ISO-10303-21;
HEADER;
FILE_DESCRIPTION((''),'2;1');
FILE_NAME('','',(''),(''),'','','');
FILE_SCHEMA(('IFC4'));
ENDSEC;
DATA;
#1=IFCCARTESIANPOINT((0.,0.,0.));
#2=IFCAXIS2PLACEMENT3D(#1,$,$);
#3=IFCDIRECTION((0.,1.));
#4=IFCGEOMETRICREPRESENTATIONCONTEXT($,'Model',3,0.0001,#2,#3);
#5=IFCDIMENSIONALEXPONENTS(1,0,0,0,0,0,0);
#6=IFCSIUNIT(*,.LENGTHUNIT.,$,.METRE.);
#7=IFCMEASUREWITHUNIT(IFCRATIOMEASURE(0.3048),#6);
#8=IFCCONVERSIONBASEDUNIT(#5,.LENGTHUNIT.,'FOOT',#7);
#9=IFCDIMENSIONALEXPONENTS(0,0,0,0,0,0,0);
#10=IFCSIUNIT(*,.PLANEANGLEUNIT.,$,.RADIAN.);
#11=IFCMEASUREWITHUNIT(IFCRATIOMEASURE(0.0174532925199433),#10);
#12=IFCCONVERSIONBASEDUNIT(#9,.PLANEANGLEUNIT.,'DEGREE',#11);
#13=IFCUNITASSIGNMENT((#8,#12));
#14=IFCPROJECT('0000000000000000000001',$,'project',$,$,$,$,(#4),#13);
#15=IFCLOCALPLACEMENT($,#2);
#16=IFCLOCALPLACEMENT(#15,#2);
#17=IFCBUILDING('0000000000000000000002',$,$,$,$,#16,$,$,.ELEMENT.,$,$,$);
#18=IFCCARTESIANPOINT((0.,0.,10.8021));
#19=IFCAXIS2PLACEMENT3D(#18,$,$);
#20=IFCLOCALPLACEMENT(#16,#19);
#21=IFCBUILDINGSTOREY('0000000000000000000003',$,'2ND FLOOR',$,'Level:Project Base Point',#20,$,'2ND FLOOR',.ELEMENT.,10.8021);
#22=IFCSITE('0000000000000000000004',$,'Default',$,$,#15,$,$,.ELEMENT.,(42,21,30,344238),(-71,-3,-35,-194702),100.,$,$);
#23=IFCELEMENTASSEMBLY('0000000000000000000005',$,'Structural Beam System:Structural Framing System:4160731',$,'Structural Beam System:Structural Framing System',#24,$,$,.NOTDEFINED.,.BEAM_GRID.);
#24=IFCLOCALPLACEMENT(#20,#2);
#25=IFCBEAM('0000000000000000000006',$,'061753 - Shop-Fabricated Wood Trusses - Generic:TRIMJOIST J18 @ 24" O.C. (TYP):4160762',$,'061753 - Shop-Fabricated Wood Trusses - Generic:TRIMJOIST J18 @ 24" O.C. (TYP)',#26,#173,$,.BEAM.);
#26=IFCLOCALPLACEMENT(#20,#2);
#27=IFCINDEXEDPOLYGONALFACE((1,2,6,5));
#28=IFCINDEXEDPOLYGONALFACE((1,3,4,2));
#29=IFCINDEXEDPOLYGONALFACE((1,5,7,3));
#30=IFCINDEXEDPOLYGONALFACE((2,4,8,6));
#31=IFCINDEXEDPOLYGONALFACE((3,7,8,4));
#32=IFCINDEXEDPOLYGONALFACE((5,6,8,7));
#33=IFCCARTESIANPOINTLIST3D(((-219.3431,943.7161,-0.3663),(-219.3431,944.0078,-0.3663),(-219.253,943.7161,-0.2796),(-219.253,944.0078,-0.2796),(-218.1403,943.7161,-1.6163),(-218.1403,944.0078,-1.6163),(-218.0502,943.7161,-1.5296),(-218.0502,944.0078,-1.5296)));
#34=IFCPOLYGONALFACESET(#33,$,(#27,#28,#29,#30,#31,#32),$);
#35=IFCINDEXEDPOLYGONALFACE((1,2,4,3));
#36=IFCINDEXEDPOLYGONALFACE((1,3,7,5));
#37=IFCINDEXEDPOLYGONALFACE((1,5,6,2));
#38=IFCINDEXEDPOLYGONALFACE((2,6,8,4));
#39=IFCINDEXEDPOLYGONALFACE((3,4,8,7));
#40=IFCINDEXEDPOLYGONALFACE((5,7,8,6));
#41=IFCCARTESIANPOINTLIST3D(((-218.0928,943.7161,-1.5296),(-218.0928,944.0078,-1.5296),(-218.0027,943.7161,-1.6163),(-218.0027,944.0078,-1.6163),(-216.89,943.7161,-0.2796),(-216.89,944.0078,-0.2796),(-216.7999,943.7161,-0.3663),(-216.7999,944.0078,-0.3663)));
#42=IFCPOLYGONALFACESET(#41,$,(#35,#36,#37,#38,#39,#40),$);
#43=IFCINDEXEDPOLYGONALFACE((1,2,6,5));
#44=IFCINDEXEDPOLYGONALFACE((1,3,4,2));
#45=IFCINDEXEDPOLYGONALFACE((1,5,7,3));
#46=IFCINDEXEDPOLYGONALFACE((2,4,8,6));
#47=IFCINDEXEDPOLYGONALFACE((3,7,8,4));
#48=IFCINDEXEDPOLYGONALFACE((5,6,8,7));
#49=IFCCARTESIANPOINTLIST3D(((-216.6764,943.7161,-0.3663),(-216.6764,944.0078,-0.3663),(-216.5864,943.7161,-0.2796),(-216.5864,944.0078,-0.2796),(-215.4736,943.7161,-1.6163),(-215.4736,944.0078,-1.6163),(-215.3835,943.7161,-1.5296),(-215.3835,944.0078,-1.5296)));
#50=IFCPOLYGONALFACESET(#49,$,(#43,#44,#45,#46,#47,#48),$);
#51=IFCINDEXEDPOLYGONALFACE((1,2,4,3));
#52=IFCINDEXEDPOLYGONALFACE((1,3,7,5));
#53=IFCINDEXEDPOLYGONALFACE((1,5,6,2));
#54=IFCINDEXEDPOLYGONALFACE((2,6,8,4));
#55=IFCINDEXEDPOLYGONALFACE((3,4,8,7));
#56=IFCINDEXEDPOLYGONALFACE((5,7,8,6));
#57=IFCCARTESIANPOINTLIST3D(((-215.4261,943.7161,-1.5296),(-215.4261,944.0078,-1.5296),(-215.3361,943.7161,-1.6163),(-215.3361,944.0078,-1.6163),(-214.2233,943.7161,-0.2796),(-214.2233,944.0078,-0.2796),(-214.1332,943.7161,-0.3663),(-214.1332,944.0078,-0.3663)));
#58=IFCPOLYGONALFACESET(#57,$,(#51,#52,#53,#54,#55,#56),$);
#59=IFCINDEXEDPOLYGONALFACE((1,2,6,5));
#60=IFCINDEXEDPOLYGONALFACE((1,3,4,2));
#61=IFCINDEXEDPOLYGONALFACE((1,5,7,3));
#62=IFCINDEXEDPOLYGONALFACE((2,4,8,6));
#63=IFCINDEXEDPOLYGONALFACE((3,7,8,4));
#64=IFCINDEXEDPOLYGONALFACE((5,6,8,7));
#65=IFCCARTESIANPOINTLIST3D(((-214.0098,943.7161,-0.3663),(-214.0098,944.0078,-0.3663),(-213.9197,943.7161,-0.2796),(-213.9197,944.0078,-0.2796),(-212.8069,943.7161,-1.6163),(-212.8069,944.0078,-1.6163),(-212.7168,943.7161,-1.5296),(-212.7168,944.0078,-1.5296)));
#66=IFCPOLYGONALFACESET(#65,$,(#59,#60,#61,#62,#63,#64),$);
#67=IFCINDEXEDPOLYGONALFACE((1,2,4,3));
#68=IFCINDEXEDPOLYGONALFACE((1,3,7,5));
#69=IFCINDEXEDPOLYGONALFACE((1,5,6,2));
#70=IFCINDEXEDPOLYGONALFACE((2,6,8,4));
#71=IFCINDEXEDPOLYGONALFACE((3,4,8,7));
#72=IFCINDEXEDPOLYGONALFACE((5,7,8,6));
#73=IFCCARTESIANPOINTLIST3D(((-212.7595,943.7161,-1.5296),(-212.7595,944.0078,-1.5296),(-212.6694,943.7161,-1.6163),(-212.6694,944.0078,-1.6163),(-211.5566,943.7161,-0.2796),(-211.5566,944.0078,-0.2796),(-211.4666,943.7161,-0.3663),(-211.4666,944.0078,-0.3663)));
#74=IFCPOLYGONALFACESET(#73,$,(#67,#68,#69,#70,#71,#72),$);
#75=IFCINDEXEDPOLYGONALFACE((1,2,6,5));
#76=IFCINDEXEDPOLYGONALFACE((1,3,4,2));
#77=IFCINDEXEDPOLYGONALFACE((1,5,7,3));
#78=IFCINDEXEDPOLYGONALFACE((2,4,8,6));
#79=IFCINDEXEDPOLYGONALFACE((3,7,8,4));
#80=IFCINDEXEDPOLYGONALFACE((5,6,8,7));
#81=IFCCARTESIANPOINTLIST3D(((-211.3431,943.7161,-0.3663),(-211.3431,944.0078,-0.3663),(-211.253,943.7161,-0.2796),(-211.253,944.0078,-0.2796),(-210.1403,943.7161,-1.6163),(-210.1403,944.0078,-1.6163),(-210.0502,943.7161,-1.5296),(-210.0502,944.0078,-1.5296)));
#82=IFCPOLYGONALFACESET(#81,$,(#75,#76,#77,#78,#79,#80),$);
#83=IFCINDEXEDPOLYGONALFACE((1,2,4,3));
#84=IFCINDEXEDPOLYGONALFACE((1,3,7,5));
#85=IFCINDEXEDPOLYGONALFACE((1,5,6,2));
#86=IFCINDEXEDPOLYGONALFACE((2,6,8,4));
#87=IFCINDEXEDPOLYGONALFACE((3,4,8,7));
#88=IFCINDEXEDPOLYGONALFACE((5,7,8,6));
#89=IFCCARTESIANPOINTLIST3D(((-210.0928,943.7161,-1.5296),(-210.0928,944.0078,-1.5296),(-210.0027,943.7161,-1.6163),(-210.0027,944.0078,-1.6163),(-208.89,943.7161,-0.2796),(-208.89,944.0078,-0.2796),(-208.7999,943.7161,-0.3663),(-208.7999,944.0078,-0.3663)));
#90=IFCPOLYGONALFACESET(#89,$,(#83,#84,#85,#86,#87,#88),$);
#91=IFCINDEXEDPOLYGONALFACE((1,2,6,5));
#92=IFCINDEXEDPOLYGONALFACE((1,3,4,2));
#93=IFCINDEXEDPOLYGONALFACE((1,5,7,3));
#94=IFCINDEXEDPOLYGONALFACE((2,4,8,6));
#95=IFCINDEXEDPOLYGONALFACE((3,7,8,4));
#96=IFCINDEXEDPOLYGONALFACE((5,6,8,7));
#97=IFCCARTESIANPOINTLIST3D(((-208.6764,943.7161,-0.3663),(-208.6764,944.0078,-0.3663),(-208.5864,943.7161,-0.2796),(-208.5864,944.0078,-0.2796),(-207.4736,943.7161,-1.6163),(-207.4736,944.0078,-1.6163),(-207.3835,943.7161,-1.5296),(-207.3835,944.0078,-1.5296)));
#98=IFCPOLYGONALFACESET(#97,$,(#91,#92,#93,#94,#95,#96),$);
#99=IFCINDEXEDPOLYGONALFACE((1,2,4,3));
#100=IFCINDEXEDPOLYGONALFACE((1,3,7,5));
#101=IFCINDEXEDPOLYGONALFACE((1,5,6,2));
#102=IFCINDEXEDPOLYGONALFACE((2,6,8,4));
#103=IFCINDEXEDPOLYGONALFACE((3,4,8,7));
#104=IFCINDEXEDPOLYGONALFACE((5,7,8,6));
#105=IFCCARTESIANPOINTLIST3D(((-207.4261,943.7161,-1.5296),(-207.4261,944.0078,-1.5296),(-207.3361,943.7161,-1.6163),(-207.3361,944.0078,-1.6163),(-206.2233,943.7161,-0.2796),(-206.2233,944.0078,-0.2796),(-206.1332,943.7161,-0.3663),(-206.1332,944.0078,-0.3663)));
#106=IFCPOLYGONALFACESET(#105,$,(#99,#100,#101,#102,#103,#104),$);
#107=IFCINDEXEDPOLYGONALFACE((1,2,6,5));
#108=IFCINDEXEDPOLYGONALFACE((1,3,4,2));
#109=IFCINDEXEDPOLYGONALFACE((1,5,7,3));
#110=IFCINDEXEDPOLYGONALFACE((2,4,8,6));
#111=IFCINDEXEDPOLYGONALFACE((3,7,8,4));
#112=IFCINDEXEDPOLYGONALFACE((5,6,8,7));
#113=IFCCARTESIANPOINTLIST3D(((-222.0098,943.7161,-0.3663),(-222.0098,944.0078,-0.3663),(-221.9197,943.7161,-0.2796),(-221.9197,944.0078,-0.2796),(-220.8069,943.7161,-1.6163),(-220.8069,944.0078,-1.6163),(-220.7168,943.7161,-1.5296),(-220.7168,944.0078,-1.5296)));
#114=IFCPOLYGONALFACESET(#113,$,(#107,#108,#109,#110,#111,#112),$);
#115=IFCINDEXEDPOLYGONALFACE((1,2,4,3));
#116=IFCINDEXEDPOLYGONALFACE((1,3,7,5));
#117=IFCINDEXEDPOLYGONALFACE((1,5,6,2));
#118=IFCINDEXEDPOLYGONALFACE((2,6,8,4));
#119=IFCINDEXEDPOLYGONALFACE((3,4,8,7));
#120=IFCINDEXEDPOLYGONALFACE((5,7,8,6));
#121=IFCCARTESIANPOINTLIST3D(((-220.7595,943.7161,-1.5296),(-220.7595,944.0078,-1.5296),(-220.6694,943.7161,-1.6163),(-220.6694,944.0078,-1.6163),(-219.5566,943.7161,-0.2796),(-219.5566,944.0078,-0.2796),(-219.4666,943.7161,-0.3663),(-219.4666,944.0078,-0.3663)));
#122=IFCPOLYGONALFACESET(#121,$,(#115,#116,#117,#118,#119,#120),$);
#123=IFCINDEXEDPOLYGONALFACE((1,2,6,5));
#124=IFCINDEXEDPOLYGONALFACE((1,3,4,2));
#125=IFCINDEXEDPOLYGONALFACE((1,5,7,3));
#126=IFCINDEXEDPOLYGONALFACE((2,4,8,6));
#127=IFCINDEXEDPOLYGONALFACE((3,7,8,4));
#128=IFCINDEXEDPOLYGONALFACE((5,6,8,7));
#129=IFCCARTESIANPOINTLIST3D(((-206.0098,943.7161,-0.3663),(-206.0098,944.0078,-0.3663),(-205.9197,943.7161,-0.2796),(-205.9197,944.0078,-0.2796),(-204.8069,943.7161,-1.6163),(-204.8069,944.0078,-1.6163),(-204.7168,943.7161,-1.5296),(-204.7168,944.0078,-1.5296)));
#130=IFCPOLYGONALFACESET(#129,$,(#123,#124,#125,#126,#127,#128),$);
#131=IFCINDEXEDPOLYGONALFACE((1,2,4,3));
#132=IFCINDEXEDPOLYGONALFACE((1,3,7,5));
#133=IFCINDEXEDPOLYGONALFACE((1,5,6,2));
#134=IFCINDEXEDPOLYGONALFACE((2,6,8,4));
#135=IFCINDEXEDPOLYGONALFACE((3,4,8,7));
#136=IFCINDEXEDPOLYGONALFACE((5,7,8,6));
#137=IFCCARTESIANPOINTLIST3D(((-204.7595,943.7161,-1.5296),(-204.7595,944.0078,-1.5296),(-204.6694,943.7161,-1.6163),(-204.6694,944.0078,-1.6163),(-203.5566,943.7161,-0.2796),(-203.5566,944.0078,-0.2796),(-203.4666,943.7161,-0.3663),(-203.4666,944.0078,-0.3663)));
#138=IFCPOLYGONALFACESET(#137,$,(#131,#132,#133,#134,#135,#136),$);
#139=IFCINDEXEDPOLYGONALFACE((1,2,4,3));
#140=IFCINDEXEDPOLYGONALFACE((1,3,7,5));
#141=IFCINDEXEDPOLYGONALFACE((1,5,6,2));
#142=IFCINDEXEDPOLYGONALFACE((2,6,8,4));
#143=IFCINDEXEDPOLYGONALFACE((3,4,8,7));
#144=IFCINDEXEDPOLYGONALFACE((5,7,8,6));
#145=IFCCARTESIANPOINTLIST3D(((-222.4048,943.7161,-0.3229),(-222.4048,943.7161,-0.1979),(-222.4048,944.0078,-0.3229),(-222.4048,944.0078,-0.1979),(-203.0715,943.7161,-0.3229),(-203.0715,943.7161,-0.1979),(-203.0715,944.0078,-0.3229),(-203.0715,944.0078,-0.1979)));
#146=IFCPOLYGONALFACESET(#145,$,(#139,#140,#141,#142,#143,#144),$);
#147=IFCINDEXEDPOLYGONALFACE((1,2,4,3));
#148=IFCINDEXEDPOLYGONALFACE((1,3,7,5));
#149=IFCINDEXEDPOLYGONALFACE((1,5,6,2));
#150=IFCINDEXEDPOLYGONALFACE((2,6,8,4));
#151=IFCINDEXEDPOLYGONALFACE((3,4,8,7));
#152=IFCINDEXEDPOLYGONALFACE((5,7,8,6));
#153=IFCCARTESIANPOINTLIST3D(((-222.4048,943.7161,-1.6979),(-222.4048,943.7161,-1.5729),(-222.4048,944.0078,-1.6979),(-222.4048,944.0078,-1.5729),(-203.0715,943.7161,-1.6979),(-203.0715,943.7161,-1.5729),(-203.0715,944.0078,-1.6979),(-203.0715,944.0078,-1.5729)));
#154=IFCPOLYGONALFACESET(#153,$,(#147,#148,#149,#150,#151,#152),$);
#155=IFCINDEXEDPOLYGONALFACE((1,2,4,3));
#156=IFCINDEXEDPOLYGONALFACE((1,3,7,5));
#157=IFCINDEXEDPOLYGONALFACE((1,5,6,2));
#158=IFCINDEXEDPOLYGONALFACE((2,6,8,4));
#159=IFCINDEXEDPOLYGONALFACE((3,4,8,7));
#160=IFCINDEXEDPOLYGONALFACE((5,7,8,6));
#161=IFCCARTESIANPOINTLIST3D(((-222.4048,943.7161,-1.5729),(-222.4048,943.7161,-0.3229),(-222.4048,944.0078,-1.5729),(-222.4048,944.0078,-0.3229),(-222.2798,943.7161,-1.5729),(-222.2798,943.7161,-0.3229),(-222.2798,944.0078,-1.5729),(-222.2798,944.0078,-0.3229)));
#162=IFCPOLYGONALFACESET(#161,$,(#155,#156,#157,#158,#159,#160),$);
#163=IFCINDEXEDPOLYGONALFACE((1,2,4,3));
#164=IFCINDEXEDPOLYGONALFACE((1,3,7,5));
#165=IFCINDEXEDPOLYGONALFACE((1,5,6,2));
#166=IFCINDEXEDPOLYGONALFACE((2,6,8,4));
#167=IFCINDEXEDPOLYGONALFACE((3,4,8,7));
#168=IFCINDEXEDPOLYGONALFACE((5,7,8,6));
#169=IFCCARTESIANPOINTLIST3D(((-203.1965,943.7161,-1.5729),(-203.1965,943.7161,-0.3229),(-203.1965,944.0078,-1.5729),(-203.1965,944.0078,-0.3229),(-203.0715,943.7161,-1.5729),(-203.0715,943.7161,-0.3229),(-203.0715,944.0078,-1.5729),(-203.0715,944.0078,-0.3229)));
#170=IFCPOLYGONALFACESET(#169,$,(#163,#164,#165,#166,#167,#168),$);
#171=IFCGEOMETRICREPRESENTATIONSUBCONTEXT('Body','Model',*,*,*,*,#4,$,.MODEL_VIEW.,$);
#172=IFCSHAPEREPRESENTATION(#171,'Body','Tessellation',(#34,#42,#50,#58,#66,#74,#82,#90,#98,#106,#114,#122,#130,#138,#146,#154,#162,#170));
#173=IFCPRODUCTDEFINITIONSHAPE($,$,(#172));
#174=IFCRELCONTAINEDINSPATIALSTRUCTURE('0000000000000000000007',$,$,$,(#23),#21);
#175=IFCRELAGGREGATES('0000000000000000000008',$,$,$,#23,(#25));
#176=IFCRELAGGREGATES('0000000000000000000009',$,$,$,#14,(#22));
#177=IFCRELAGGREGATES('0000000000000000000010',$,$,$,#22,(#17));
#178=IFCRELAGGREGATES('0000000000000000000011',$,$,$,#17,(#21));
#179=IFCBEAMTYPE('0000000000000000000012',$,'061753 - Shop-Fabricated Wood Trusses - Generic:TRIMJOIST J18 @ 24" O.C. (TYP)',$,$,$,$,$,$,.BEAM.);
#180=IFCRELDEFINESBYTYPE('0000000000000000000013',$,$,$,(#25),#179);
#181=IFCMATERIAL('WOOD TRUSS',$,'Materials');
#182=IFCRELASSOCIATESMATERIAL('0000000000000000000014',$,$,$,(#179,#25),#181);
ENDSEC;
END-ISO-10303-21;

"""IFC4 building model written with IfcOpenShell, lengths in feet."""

from ifc_helpers import new_model, entity, si_unit, converted_unit, direction, frame, frame_2d, origin, origin_2d_with_axis, place, context, subcontext, project, spatial, rectangle, extrude, source, transform, mapped, material, material_profile, profile_set, profile_usage, type_object, type_shapes, element, aggregate, save


model = new_model("IFC4")

# Units and contexts
model_context = context("Model", 3, precision=0.0001, world=origin(), true_north=direction((0.0, 1.0)))
body_context = subcontext(model_context, "Body", "Model", "MODEL_VIEW")
ifc_project = project(units=[converted_unit("LENGTHUNIT", "FOOT", entity("IfcRatioMeasure", 0.3048), si_unit("LENGTHUNIT", "METRE"), dimensions=[1, 0, 0, 0, 0, 0, 0]), converted_unit("PLANEANGLEUNIT", "DEGREE", entity("IfcRatioMeasure", 0.0174532925199433), si_unit("PLANEANGLEUNIT", "RADIAN"), dimensions=[0, 0, 0, 0, 0, 0, 0])], contexts=[model_context])

# Site, building, storey
site_placement = place(None, origin())
site = spatial("IfcSite", under=ifc_project, at=site_placement, Name="Default", CompositionType="ELEMENT", RefLatitude=(42, 21, 30, 344238), RefLongitude=(-71, -3, -35, -194702), RefElevation=100.0)
building_placement = place(site_placement, origin())
building = spatial("IfcBuilding", under=site, at=building_placement, CompositionType="ELEMENT")
storey_placement = place(building_placement, frame((0.0, 0.0, 10.8021)))
storey = spatial("IfcBuildingStorey", under=building, at=storey_placement, Name="2ND FLOOR", ObjectType="Level:Project Base Point", LongName="2ND FLOOR", CompositionType="ELEMENT", Elevation=10.8021)

# Element assembly, beam
ifc_material_1 = material(Name="WOOD TRUSS", Category="Materials")
ifc_material_profile_1 = material_profile(ifc_material_1, rectangle(XDim=1.7347, YDim=0.125, at=frame_2d((0.0, 0.0), x_axis=(1.0, 0.0))), Name="TRIMJOIST J18 @ 24\" O.C. (TYP)")
ifc_material_profile_2 = material_profile(ifc_material_1, rectangle(XDim=1.7347, YDim=0.125, at=frame_2d((0.0, 0.0), x_axis=(1.0, 0.0))), Name="TRIMJOIST J18 @ 24\" O.C. (TYP)")
ifc_material_profile_3 = material_profile(ifc_material_1, rectangle(XDim=1.7347, YDim=0.125, at=frame_2d((0.0, 0.0), x_axis=(1.0, 0.0))), Name="TRIMJOIST J18 @ 24\" O.C. (TYP)")
ifc_material_profile_4 = material_profile(ifc_material_1, rectangle(XDim=1.7347, YDim=0.125, at=frame_2d((0.0, 0.0), x_axis=(1.0, 0.0))), Name="TRIMJOIST J18 @ 24\" O.C. (TYP)")
ifc_material_profile_5 = material_profile(ifc_material_1, rectangle(XDim=1.7347, YDim=0.125, at=frame_2d((0.0, 0.0), x_axis=(1.0, 0.0))), Name="TRIMJOIST J18 @ 24\" O.C. (TYP)")
ifc_material_profile_6 = material_profile(ifc_material_1, rectangle(XDim=1.7347, YDim=0.125, at=frame_2d((0.0, 0.0), x_axis=(1.0, 0.0))), Name="TRIMJOIST J18 @ 24\" O.C. (TYP)")
ifc_material_profile_7 = material_profile(ifc_material_1, rectangle(XDim=1.7347, YDim=0.125, at=frame_2d((0.0, 0.0), x_axis=(1.0, 0.0))), Name="TRIMJOIST J18 @ 24\" O.C. (TYP)")
ifc_material_profile_8 = material_profile(ifc_material_1, rectangle(XDim=1.7347, YDim=0.125, at=frame_2d((0.0, 0.0), x_axis=(1.0, 0.0))), Name="TRIMJOIST J18 @ 24\" O.C. (TYP)")
ifc_material_profile_9 = material_profile(ifc_material_1, rectangle(XDim=1.7347, YDim=0.125, at=frame_2d((0.0, 0.0), x_axis=(1.0, 0.0))), Name="TRIMJOIST J18 @ 24\" O.C. (TYP)")
ifc_material_profile_10 = material_profile(ifc_material_1, rectangle(XDim=1.7347, YDim=0.125, at=origin_2d_with_axis()), Name="TRIMJOIST J18 @ 24\" O.C. (TYP)")
ifc_material_profile_11 = material_profile(ifc_material_1, rectangle(XDim=0.125, YDim=0.2917, at=origin_2d_with_axis()), Name="TRIMJOIST J18 @ 24\" O.C. (TYP)")
ifc_material_profile_12 = material_profile(ifc_material_1, rectangle(XDim=0.125, YDim=0.2917, at=origin_2d_with_axis()), Name="TRIMJOIST J18 @ 24\" O.C. (TYP)")
ifc_material_profile_13 = material_profile(ifc_material_1, rectangle(XDim=1.25, YDim=0.2917, at=origin_2d_with_axis()), Name="TRIMJOIST J18 @ 24\" O.C. (TYP)")
ifc_material_profile_14 = material_profile(ifc_material_1, rectangle(XDim=1.25, YDim=0.2917, at=origin_2d_with_axis()), Name="TRIMJOIST J18 @ 24\" O.C. (TYP)")
ifc_profile_set_1 = profile_set([ifc_material_profile_1, ifc_material_profile_2, ifc_material_profile_3, ifc_material_profile_4, ifc_material_profile_5, ifc_material_profile_6, ifc_material_profile_7, ifc_material_profile_8, ifc_material_profile_9, ifc_material_profile_10, ifc_material_profile_11, ifc_material_profile_12, ifc_material_profile_13, ifc_material_profile_14], Name="TRIMJOIST J18 @ 24\" O.C. (TYP)")
beam_type_1 = type_object("IfcBeamType", Name="061753 - Shop-Fabricated Wood Trusses - Generic:TRIMJOIST J18 @ 24\" O.C. (TYP)", PredefinedType="BEAM", material=ifc_profile_set_1)
shared_shape_1 = source(origin(), body_context, "Body", "SweptSolid", [
    extrude(rectangle(XDim=1.7347, YDim=0.125, at=frame_2d((0.0, 0.0), x_axis=(1.0, 0.0))), frame((5.9585, -0.1458, 0.0), z_axis=(0.0, 1.0, 0.0), x_axis=(0.693383, 0.0, 0.720569)), (0.0, 0.0, 1.0), 0.2917),
    extrude(rectangle(XDim=1.7347, YDim=0.125, at=origin_2d_with_axis()), frame((4.7082, -0.1458, 0.0), z_axis=(0.0, 1.0, 0.0), x_axis=(0.693383, 0.0, -0.720569)), (0.0, 0.0, 1.0), 0.2917),
    extrude(rectangle(XDim=1.7347, YDim=0.125, at=frame_2d((0.0, 0.0), x_axis=(1.0, 0.0))), frame((3.2918, -0.1458, 0.0), z_axis=(0.0, 1.0, 0.0), x_axis=(0.693383, 0.0, 0.720569)), (0.0, 0.0, 1.0), 0.2917),
    extrude(rectangle(XDim=1.7347, YDim=0.125, at=frame_2d((0.0, 0.0), x_axis=(1.0, 0.0))), frame((2.0415, -0.1458, 0.0), z_axis=(0.0, 1.0, 0.0), x_axis=(0.693383, 0.0, -0.720569)), (0.0, 0.0, 1.0), 0.2917),
    extrude(rectangle(XDim=1.7347, YDim=0.125, at=frame_2d((0.0, 0.0), x_axis=(1.0, 0.0))), frame((0.6251, -0.1458, 0.0), z_axis=(0.0, 1.0, 0.0), x_axis=(0.693383, 0.0, 0.720569)), (0.0, 0.0, 1.0), 0.2917),
    extrude(rectangle(XDim=1.7347, YDim=0.125, at=frame_2d((0.0, 0.0), x_axis=(1.0, 0.0))), frame((-0.6251, -0.1458, 0.0), z_axis=(0.0, 1.0, 0.0), x_axis=(0.693383, 0.0, -0.720569)), (0.0, 0.0, 1.0), 0.2917),
    extrude(rectangle(XDim=1.7347, YDim=0.125, at=frame_2d((0.0, 0.0), x_axis=(1.0, 0.0))), frame((-2.0415, -0.1458, 0.0), z_axis=(0.0, 1.0, 0.0), x_axis=(0.693383, 0.0, 0.720569)), (0.0, 0.0, 1.0), 0.2917),
    extrude(rectangle(XDim=1.7347, YDim=0.125, at=origin_2d_with_axis()), frame((-3.2918, -0.1458, 0.0), z_axis=(0.0, 1.0, 0.0), x_axis=(0.693383, 0.0, -0.720569)), (0.0, 0.0, 1.0), 0.2917),
    extrude(rectangle(XDim=1.7347, YDim=0.125, at=frame_2d((0.0, 0.0), x_axis=(1.0, 0.0))), frame((-4.7082, -0.1458, 0.0), z_axis=(0.0, 1.0, 0.0), x_axis=(0.693383, 0.0, 0.720569)), (0.0, 0.0, 1.0), 0.2917),
    extrude(rectangle(XDim=1.7347, YDim=0.125, at=frame_2d((0.0, 0.0), x_axis=(1.0, 0.0))), frame((-5.9585, -0.1458, 0.0), z_axis=(0.0, 1.0, 0.0), x_axis=(0.693383, 0.0, -0.720569)), (0.0, 0.0, 1.0), 0.2917),
    extrude(rectangle(XDim=1.7347, YDim=0.125, at=frame_2d((0.0, 0.0), x_axis=(1.0, 0.0))), frame((8.6251, -0.1458, 0.0), z_axis=(0.0, 1.0, 0.0), x_axis=(0.693383, 0.0, 0.720569)), (0.0, 0.0, 1.0), 0.2917),
    extrude(rectangle(XDim=1.7347, YDim=0.125, at=origin_2d_with_axis()), frame((7.3749, -0.1458, 0.0), z_axis=(0.0, 1.0, 0.0), x_axis=(0.693383, 0.0, -0.720569)), (0.0, 0.0, 1.0), 0.2917),
    extrude(rectangle(XDim=1.7347, YDim=0.125, at=frame_2d((0.0, 0.0), x_axis=(1.0, 0.0))), frame((-7.3749, -0.1458, 0.0), z_axis=(0.0, 1.0, 0.0), x_axis=(0.693383, 0.0, 0.720569)), (0.0, 0.0, 1.0), 0.2917),
    extrude(rectangle(XDim=1.7347, YDim=0.125, at=origin_2d_with_axis()), frame((-8.6251, -0.1458, 0.0), z_axis=(0.0, 1.0, 0.0), x_axis=(0.693383, 0.0, -0.720569)), (0.0, 0.0, 1.0), 0.2917),
    extrude(rectangle(XDim=0.125, YDim=0.2917, at=origin_2d_with_axis()), frame((-9.6667, 0.0, 0.6875), z_axis=(1.0, 0.0, 0.0), x_axis=(0.0, 0.0, -1.0)), (0.0, 0.0, 1.0), 19.3333),
    extrude(rectangle(XDim=0.125, YDim=0.2917, at=origin_2d_with_axis()), frame((-9.6667, 0.0, -0.6875), z_axis=(1.0, 0.0, 0.0), x_axis=(0.0, 0.0, -1.0)), (0.0, 0.0, 1.0), 19.3333),
    extrude(rectangle(XDim=1.25, YDim=0.2917, at=origin_2d_with_axis()), frame((9.5417, 0.0, 0.0), z_axis=(1.0, 0.0, 0.0), x_axis=(0.0, 0.0, -1.0)), (0.0, 0.0, 1.0), 0.125),
    extrude(rectangle(XDim=1.25, YDim=0.2917, at=origin_2d_with_axis()), frame((-9.6667, 0.0, 0.0), z_axis=(1.0, 0.0, 0.0), x_axis=(0.0, 0.0, -1.0)), (0.0, 0.0, 1.0), 0.125),
])
type_shapes(beam_type_1, [shared_shape_1])
assembly_1_placement = place(storey_placement, origin())
assembly_1 = element("IfcElementAssembly", 1, at=assembly_1_placement, inside=storey, Name="Structural Beam System:Structural Framing System:4160731", ObjectType="Structural Beam System:Structural Framing System", AssemblyPlace="NOTDEFINED", PredefinedType="BEAM_GRID")
ifc_profile_usage_1 = profile_usage(ifc_profile_set_1, cardinal=8)
beam_1_placement = place(assembly_1_placement, frame((-212.7382, 943.8619, -0.9479), z_axis=(0.0, 0.0, 1.0), x_axis=(-1.0, 0.0, 0.0)))
beam_1 = element("IfcBeam", 2, at=beam_1_placement, type_object=beam_type_1, material=ifc_profile_usage_1, Name="061753 - Shop-Fabricated Wood Trusses - Generic:TRIMJOIST J18 @ 24\" O.C. (TYP):4160762", ObjectType="061753 - Shop-Fabricated Wood Trusses - Generic:TRIMJOIST J18 @ 24\" O.C. (TYP)", PredefinedType="BEAM", context=body_context, shape_type="MappedRepresentation", body=[
    mapped(shared_shape_1, transform((0.0, 0.0, 0.0), scale=1.0)),
])
aggregate(assembly_1, [beam_1])

save(model, "model.ifc")
